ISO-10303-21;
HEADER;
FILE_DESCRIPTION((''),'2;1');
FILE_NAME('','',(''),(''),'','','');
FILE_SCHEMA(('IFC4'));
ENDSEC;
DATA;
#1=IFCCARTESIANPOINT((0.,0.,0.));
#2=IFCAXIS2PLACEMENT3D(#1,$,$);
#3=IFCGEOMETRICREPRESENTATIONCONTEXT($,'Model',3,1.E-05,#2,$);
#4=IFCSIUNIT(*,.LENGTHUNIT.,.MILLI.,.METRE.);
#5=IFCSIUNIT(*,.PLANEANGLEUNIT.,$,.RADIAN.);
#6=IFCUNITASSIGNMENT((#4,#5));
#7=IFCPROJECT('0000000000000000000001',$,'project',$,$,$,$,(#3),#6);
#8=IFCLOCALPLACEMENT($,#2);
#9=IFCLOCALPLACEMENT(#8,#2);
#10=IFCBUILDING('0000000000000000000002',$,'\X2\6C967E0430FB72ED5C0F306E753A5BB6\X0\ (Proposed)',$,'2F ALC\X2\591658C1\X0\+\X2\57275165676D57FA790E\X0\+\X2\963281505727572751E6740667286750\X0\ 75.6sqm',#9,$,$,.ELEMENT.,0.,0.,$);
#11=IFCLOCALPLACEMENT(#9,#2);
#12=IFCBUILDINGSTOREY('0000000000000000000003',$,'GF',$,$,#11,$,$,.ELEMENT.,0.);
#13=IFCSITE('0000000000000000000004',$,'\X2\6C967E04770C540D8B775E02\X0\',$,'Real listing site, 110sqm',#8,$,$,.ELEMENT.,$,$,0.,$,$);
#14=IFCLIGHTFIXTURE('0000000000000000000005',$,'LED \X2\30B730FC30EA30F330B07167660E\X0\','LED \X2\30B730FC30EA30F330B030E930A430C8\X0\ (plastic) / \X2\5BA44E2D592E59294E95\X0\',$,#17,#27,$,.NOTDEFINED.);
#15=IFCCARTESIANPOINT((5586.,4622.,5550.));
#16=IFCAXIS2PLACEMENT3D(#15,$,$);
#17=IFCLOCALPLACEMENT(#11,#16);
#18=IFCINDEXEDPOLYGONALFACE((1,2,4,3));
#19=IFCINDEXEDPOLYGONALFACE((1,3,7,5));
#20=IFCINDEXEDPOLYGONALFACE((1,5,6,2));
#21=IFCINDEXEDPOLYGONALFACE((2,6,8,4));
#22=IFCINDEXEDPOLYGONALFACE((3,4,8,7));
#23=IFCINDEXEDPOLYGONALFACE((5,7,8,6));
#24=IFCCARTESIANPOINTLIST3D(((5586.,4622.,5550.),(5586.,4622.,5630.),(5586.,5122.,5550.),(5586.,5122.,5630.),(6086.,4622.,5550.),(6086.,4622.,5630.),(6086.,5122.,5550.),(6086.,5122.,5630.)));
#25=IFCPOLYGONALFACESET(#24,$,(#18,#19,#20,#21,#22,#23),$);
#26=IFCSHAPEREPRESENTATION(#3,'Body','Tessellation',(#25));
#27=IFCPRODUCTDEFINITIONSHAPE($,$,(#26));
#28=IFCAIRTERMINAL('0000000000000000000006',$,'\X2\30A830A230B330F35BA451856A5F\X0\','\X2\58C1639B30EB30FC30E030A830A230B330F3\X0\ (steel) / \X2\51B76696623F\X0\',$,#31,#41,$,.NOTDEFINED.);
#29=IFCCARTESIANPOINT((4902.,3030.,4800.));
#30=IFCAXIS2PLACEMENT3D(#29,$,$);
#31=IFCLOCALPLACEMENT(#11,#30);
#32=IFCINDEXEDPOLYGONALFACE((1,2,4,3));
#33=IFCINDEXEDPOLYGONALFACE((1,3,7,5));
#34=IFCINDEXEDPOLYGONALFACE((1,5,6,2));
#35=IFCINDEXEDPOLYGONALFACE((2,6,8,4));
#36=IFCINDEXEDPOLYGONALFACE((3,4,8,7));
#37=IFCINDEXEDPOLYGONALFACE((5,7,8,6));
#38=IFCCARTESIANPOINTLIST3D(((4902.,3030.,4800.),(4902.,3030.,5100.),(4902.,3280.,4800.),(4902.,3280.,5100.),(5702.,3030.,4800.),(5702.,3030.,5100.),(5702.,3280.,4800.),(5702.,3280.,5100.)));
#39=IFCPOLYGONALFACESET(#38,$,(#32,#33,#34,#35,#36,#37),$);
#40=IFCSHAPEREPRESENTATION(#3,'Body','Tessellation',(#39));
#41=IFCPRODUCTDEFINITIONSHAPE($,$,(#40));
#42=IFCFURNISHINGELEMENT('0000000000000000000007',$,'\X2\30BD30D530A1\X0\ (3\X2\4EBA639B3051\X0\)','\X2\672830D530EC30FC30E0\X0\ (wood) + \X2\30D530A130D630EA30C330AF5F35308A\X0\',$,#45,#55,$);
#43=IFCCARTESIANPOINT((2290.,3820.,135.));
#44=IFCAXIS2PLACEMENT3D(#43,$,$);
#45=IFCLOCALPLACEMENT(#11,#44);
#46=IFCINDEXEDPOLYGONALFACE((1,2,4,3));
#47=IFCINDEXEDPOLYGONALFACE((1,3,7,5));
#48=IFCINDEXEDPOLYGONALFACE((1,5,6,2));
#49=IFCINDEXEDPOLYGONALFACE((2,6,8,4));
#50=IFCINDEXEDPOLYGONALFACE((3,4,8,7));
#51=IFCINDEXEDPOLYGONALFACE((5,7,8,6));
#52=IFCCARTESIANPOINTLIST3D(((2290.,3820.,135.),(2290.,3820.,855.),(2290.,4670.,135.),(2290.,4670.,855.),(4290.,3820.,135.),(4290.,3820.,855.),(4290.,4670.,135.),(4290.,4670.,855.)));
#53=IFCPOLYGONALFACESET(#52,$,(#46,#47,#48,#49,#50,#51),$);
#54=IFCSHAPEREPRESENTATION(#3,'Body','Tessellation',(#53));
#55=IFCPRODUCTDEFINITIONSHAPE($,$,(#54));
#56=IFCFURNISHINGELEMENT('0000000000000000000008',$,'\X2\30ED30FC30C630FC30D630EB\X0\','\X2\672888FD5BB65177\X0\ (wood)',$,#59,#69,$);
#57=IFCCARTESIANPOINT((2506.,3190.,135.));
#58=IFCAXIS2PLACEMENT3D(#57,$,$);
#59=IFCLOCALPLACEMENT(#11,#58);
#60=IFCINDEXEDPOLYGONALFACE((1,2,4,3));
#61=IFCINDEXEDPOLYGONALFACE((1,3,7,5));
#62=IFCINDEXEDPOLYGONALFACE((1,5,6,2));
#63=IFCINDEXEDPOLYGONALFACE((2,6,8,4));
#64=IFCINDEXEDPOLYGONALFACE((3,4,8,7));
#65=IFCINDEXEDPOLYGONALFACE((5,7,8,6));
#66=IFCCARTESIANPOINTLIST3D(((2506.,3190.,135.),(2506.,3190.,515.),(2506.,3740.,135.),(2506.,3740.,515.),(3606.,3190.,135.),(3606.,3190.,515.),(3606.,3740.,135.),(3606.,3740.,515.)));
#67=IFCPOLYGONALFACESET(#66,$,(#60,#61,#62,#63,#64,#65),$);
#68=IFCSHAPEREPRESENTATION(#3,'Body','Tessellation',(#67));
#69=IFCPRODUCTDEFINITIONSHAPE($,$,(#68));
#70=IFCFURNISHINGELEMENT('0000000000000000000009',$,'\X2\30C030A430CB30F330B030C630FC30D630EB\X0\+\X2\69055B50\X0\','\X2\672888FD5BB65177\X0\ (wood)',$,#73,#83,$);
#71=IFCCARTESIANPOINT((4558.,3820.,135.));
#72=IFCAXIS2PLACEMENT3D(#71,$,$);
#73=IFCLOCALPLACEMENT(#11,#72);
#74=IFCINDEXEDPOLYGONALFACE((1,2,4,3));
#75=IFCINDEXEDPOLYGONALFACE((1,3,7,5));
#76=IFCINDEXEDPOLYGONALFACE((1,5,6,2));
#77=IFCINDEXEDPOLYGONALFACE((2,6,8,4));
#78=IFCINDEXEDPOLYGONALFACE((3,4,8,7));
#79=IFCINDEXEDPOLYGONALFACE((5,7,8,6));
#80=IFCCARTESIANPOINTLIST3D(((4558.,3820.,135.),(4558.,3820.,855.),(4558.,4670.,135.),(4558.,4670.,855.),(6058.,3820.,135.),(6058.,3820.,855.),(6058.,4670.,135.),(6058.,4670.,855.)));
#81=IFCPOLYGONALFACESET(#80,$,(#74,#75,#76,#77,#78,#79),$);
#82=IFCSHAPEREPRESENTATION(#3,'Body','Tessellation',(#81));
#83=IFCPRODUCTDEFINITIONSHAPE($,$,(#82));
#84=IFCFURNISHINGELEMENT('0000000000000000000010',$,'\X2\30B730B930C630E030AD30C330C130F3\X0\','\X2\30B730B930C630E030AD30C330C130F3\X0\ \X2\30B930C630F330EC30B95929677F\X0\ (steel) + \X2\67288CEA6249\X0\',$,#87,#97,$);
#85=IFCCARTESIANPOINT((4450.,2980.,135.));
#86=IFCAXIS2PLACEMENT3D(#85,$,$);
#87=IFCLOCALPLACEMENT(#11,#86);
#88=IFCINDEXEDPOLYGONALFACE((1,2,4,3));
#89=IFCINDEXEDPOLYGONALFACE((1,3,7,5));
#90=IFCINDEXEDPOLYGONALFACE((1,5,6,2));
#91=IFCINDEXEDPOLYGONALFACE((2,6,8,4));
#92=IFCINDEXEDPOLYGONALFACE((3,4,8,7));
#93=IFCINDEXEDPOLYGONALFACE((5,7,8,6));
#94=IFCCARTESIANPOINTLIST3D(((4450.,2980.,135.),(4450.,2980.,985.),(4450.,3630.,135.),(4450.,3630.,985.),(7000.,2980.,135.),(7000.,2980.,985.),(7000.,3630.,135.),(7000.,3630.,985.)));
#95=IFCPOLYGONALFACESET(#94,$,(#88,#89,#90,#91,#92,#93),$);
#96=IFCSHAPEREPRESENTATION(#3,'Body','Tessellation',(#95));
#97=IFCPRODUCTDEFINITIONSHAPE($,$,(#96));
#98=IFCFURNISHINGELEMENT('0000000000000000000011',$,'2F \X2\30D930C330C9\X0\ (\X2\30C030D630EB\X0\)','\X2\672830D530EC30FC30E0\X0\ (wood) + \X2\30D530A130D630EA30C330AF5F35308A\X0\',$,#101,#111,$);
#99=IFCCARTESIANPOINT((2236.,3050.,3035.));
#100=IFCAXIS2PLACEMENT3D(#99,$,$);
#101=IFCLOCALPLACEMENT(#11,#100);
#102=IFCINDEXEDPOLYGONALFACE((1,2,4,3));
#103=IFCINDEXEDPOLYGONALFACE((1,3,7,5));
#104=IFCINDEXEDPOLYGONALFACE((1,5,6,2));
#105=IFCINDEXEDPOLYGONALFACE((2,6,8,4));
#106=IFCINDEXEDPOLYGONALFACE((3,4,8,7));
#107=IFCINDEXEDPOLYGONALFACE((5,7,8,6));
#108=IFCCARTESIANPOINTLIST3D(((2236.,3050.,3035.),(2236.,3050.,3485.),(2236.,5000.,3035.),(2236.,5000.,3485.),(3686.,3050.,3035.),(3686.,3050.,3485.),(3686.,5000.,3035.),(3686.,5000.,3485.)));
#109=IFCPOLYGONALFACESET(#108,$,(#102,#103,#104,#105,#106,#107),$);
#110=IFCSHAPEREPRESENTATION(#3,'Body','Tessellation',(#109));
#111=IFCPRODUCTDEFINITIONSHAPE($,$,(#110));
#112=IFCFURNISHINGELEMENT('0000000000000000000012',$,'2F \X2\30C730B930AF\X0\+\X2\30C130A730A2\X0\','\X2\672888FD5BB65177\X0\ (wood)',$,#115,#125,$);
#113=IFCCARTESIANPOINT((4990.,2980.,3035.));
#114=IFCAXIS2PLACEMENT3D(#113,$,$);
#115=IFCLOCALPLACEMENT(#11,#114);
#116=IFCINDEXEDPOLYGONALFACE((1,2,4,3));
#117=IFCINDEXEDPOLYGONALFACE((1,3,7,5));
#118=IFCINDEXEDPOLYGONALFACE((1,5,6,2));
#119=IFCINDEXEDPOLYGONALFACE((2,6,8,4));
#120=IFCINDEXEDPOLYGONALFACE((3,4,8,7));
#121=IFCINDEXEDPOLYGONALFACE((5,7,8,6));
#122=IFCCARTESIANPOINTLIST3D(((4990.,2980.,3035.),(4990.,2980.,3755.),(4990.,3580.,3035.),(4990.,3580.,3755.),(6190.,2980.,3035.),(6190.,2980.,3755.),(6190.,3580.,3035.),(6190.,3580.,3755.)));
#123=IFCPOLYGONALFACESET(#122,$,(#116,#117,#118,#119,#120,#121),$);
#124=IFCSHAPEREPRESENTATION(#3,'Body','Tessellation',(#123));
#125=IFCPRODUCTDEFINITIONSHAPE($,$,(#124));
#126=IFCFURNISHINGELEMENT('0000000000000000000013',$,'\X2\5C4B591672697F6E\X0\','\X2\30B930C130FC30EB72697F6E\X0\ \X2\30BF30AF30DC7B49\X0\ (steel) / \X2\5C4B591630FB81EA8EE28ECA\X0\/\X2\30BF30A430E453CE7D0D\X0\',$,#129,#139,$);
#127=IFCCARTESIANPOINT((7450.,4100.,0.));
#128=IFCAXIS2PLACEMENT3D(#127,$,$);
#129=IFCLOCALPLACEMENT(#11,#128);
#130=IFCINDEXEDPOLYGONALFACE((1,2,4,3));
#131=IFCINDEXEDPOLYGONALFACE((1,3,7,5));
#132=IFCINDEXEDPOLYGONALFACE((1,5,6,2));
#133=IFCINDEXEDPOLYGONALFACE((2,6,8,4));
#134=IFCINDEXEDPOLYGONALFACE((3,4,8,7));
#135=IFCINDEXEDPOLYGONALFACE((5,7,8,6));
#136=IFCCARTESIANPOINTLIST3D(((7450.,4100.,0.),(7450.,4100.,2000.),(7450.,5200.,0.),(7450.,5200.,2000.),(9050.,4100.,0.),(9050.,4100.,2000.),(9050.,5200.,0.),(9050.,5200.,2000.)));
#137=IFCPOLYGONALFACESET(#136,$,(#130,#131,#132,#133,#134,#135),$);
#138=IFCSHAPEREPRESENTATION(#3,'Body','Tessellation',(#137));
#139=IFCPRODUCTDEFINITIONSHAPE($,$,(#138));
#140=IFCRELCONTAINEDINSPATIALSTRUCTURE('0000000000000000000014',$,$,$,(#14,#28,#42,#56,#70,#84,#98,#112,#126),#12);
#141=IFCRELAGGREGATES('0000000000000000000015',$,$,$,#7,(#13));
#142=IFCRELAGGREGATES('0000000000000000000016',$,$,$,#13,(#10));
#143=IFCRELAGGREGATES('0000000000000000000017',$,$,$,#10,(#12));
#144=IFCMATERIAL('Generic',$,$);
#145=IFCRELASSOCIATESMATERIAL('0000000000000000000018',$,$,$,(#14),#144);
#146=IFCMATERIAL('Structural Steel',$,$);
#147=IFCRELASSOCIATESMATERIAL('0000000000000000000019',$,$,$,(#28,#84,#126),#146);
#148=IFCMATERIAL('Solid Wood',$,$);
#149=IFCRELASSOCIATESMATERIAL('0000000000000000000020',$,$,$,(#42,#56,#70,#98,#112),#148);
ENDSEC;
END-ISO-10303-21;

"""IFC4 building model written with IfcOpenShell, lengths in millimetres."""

from ifc_helpers import new_model, si_unit, frame, frame_2d, origin, place, context, project, spatial, rectangle, extrude, material, element, save


model = new_model("IFC4")

# Units and contexts
model_context = context("Model", 3, precision=1e-05, world=origin())
ifc_project = project(units=[si_unit("LENGTHUNIT", "METRE", prefix="MILLI"), si_unit("PLANEANGLEUNIT", "RADIAN")], contexts=[model_context])

# Site, building, storey
site_placement = place(None, origin())
site = spatial("IfcSite", under=ifc_project, at=site_placement, Name="沖縄県名護市", ObjectType="Real listing site, 110sqm", CompositionType="ELEMENT", RefElevation=0.0)
building_placement = place(site_placement, origin())
building = spatial("IfcBuilding", under=site, at=building_placement, Name="沖縄・狭小の町家 (Proposed)", ObjectType="2F ALC外壁+圧入杭基礎+防腐圧圧処理木材 75.6sqm", CompositionType="ELEMENT", ElevationOfRefHeight=0.0, ElevationOfTerrain=0.0)
storey_placement = place(building_placement, origin())
storey = spatial("IfcBuildingStorey", under=building, at=storey_placement, Name="GF", CompositionType="ELEMENT", Elevation=0.0)

# Shared definitions
ifc_material_1 = material(Name="Solid Wood")

# Shared definitions
ifc_material_2 = material(Name="Generic")

# Shared definitions
ifc_material_3 = material(Name="Structural Steel")

# Light fixture
light_fixture_placement = place(storey_placement, frame((5586.0, 4622.0, 5550.0)))
element("IfcLightFixture", 1, at=light_fixture_placement, inside=storey, material=ifc_material_2, Name="LED シーリング照明", Description="LED シーリングライト (plastic) / 室中央天井", PredefinedType="NOTDEFINED", context=model_context, shape_type="SweptSolid", body=[
    extrude(rectangle(XDim=500.0, YDim=500.0, at=frame_2d((250.0, 250.0))), frame((5586.0, 4622.0, 5550.0)), (0.0, 0.0, 1.0), 80.0),
])

# Air terminal
air_terminal_1_placement = place(storey_placement, frame((4902.0, 3030.0, 4800.0)))
element("IfcAirTerminal", 2, at=air_terminal_1_placement, inside=storey, material=ifc_material_3, Name="エアコン室内機", Description="壁掛ルームエアコン (steel) / 冷暖房", PredefinedType="NOTDEFINED", context=model_context, shape_type="SweptSolid", body=[
    extrude(rectangle(XDim=800.0, YDim=250.0, at=frame_2d((400.0, 125.0))), frame((4902.0, 3030.0, 4800.0)), (0.0, 0.0, 1.0), 300.0),
])

# Furnishing elements
furnishing_1_placement = place(storey_placement, frame((2290.0, 3820.0, 135.0)))
element("IfcFurnishingElement", 3, at=furnishing_1_placement, inside=storey, material=ifc_material_1, Name="ソファ (3人掛け)", Description="木フレーム (wood) + ファブリック張り", context=model_context, shape_type="SweptSolid", body=[
    extrude(rectangle(XDim=2000.0, YDim=850.0, at=frame_2d((1000.0, 425.0))), frame((2290.0, 3820.0, 135.0)), (0.0, 0.0, 1.0), 720.0),
])
furnishing_2_placement = place(storey_placement, frame((2506.0, 3190.0, 135.0)))
element("IfcFurnishingElement", 4, at=furnishing_2_placement, inside=storey, material=ifc_material_1, Name="ローテーブル", Description="木製家具 (wood)", context=model_context, shape_type="SweptSolid", body=[
    extrude(rectangle(XDim=1100.0, YDim=550.0, at=frame_2d((550.0, 275.0))), frame((2506.0, 3190.0, 135.0)), (0.0, 0.0, 1.0), 380.0),
])
furnishing_3_placement = place(storey_placement, frame((4558.0, 3820.0, 135.0)))
element("IfcFurnishingElement", 5, at=furnishing_3_placement, inside=storey, material=ifc_material_1, Name="ダイニングテーブル+椅子", Description="木製家具 (wood)", context=model_context, shape_type="SweptSolid", body=[
    extrude(rectangle(XDim=1500.0, YDim=850.0, at=frame_2d((750.0, 425.0))), frame((4558.0, 3820.0, 135.0)), (0.0, 0.0, 1.0), 720.0),
])
furnishing_4_placement = place(storey_placement, frame((4450.0, 2980.0, 135.0)))
element("IfcFurnishingElement", 6, at=furnishing_4_placement, inside=storey, material=ifc_material_3, Name="システムキッチン", Description="システムキッチン ステンレス天板 (steel) + 木質扉", context=model_context, shape_type="SweptSolid", body=[
    extrude(rectangle(XDim=2550.0, YDim=650.0, at=frame_2d((1275.0, 325.0))), frame((4450.0, 2980.0, 135.0)), (0.0, 0.0, 1.0), 850.0),
])
furnishing_5_placement = place(storey_placement, frame((2236.0, 3050.0, 3035.0)))
element("IfcFurnishingElement", 7, at=furnishing_5_placement, inside=storey, material=ifc_material_1, Name="2F ベッド (ダブル)", Description="木フレーム (wood) + ファブリック張り", context=model_context, shape_type="SweptSolid", body=[
    extrude(rectangle(XDim=1450.0, YDim=1950.0, at=frame_2d((725.0, 975.0))), frame((2236.0, 3050.0, 3035.0)), (0.0, 0.0, 1.0), 450.0),
])
furnishing_6_placement = place(storey_placement, frame((4990.0, 2980.0, 3035.0)))
element("IfcFurnishingElement", 8, at=furnishing_6_placement, inside=storey, material=ifc_material_1, Name="2F デスク+チェア", Description="木製家具 (wood)", context=model_context, shape_type="SweptSolid", body=[
    extrude(rectangle(XDim=1200.0, YDim=600.0, at=frame_2d((600.0, 300.0))), frame((4990.0, 2980.0, 3035.0)), (0.0, 0.0, 1.0), 720.0),
])
furnishing_7_placement = place(storey_placement, frame((7450.0, 4100.0, 0.0)))
element("IfcFurnishingElement", 9, at=furnishing_7_placement, inside=storey, material=ifc_material_3, Name="屋外物置", Description="スチール物置 タクボ等 (steel) / 屋外・自転車/タイヤ収納", context=model_context, shape_type="SweptSolid", body=[
    extrude(rectangle(XDim=1600.0, YDim=1100.0, at=frame_2d((800.0, 550.0))), frame((7450.0, 4100.0, 0.0)), (0.0, 0.0, 1.0), 2000.0),
])

save(model, "model.ifc")
